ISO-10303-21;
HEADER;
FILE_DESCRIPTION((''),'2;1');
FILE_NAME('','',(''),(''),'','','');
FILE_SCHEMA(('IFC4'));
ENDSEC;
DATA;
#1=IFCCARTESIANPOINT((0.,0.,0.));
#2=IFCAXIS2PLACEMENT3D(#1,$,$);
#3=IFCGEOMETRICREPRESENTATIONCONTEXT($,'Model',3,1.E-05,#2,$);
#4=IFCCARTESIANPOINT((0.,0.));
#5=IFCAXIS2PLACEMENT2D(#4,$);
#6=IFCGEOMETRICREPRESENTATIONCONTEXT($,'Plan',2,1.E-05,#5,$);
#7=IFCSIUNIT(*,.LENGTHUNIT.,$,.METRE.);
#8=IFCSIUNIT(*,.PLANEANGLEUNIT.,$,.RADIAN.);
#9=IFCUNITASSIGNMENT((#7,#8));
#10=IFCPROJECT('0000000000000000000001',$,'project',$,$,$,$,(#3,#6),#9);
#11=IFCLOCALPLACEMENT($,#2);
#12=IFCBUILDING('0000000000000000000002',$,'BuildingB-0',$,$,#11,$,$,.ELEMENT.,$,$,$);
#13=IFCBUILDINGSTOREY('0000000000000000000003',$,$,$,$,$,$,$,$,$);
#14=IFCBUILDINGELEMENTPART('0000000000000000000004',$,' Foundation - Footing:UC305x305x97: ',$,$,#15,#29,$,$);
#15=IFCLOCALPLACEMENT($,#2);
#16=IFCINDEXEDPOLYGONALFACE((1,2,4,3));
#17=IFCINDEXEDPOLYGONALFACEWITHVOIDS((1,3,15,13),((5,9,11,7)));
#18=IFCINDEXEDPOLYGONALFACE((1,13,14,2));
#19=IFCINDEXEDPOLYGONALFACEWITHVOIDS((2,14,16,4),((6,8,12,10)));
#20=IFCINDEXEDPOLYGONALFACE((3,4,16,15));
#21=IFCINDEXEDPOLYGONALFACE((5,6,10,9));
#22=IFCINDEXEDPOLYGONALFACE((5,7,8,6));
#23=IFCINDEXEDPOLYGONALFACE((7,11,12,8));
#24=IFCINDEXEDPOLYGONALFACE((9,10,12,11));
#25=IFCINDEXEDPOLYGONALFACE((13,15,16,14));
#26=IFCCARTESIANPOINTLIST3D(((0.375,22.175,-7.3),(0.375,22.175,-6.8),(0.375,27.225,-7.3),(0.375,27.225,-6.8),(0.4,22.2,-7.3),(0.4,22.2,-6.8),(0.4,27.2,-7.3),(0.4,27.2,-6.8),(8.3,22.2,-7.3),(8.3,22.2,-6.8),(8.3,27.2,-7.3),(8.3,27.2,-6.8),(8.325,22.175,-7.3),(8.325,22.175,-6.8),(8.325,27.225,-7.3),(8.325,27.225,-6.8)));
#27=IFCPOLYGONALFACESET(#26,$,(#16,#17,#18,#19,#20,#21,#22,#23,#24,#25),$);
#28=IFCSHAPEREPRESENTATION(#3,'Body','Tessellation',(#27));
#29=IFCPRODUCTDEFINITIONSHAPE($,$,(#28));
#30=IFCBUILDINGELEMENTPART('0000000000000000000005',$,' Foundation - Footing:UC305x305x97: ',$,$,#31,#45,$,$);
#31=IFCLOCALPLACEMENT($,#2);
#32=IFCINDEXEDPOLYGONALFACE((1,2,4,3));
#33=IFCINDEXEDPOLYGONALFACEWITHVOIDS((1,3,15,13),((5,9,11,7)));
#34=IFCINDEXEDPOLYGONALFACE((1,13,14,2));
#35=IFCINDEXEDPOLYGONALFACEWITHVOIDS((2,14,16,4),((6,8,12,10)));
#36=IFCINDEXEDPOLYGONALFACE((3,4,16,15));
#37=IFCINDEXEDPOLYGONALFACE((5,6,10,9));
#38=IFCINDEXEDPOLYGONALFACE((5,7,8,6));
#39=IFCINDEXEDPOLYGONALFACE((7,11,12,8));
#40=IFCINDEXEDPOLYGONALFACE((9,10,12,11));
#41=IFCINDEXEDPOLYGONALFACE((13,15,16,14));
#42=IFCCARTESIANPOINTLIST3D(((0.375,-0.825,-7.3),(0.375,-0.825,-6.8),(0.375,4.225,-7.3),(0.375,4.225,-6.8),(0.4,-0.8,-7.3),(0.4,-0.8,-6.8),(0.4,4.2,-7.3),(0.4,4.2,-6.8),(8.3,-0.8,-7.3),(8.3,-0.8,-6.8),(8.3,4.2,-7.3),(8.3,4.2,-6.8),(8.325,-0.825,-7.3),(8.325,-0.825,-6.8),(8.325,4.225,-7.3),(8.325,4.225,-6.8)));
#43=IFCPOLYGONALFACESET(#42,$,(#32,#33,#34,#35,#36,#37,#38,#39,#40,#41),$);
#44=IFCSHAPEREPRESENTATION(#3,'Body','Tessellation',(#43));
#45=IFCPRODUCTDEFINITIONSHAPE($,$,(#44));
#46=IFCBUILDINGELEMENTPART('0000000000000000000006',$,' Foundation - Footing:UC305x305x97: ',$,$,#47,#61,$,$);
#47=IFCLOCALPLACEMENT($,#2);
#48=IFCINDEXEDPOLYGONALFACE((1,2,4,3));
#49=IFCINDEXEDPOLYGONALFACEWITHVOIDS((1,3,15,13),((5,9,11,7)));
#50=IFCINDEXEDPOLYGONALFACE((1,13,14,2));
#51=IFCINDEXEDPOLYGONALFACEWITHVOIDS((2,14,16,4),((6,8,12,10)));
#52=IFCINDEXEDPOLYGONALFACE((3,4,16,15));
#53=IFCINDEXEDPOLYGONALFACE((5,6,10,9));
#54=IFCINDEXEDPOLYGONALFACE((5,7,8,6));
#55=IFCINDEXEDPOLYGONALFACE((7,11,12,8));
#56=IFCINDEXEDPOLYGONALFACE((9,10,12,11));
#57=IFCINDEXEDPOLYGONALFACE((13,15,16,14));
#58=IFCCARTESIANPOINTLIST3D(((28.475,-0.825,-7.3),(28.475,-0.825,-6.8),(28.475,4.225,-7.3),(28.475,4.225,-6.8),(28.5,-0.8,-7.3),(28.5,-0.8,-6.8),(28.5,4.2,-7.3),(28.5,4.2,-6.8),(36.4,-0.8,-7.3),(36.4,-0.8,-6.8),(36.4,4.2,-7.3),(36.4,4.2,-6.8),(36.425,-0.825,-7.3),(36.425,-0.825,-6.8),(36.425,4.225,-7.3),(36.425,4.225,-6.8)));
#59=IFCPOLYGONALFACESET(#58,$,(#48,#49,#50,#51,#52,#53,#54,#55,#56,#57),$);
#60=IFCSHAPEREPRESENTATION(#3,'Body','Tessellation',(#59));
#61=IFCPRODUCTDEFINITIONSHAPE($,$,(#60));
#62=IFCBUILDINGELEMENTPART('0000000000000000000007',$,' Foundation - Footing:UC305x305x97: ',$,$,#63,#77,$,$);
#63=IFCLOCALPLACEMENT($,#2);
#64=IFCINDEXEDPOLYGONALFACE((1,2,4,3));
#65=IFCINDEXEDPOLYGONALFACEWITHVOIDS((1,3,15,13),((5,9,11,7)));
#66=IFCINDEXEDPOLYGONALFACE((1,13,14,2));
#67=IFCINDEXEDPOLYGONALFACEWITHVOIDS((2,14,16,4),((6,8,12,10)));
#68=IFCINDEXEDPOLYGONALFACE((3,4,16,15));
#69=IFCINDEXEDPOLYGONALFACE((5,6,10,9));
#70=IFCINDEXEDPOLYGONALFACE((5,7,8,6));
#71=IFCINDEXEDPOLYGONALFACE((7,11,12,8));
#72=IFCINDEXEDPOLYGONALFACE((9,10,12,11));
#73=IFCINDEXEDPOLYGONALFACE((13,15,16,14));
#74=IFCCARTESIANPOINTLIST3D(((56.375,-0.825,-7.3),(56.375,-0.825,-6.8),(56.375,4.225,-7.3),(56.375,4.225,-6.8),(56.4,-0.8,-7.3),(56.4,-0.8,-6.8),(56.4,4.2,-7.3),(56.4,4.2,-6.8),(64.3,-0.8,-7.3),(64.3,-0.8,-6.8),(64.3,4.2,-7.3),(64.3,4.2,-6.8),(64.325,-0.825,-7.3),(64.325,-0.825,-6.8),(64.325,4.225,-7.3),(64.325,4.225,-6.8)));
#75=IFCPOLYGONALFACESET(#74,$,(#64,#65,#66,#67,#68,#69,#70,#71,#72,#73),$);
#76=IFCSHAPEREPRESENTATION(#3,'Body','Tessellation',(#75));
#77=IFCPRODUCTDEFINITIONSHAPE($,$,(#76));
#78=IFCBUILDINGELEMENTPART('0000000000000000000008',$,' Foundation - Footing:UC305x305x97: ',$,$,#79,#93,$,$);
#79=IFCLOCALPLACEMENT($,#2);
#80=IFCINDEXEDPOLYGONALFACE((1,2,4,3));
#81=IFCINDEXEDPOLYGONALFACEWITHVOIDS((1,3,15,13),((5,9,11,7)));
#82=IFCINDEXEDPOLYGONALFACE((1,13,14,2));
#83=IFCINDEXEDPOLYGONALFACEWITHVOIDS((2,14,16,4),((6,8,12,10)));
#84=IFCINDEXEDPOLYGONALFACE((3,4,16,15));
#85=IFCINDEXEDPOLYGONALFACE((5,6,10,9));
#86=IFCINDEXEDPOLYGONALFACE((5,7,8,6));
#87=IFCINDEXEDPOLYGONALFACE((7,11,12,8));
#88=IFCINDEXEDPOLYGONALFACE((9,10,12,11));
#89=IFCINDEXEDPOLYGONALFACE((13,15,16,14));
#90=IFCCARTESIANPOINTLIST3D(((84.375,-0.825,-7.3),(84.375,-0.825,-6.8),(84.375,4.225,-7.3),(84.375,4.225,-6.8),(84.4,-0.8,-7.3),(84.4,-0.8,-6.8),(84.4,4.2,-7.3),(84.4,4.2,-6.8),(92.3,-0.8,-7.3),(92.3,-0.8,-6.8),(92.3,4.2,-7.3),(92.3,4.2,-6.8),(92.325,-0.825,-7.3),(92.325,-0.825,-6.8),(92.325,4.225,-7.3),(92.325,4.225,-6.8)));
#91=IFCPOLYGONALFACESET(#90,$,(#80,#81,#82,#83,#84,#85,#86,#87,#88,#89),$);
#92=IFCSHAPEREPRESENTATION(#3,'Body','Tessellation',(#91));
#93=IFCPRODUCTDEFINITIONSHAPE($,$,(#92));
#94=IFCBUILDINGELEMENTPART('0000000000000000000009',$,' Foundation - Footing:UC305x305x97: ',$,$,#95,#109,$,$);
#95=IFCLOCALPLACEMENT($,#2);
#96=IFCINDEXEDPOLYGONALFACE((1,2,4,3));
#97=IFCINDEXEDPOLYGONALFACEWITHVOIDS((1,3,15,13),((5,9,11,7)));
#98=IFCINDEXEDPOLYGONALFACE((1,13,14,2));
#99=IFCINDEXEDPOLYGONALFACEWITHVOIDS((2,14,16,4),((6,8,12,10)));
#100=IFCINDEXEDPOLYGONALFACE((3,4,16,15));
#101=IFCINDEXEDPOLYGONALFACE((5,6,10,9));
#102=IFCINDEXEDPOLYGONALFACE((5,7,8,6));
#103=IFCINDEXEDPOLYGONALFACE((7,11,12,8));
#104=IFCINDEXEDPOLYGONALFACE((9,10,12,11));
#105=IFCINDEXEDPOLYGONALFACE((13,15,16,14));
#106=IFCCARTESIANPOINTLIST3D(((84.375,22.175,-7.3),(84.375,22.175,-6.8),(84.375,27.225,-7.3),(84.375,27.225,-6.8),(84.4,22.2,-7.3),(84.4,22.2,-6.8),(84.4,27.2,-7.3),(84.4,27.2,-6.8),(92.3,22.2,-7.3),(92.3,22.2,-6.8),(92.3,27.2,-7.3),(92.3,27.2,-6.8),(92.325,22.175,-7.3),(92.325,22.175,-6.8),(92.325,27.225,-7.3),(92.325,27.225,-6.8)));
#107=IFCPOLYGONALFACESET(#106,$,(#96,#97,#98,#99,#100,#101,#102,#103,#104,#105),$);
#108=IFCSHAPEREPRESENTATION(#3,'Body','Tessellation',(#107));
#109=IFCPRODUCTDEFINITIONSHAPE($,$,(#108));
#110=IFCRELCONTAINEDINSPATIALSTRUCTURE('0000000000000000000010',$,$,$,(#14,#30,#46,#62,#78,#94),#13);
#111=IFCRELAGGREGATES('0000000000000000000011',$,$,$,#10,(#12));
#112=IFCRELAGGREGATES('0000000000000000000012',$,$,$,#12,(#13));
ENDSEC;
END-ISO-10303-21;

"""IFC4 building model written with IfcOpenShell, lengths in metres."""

from ifc_helpers import new_model, si_unit, origin, origin_2d, place, context, project, spatial, polyline, outline, extrude, element, save


model = new_model("IFC4")

# Units and contexts
model_context = context("Model", 3, precision=1e-05, world=origin())
plan_context = context("Plan", 2, precision=1e-05, world=origin_2d())
ifc_project = project(units=[si_unit("LENGTHUNIT", "METRE"), si_unit("PLANEANGLEUNIT", "RADIAN")], contexts=[model_context, plan_context])

# Building, storey
building_placement = place(None, origin())
building = spatial("IfcBuilding", under=ifc_project, at=building_placement, Name="BuildingB-0", CompositionType="ELEMENT")
storey = spatial("IfcBuildingStorey", under=building)

# Building element parts, openings
building_element_part_1 = element("IfcBuildingElementPart", 1, inside=storey, Name=" Foundation - Footing:UC305x305x97: ", context=model_context, shape_type="SweptSolid", body=[
    extrude(outline(polyline([(8.325, 27.225, -7.3), (0.375, 27.225, -7.3), (0.375, 22.175, -7.3), (8.325, 22.175, -7.3), (8.325, 27.225, -7.3)])), None, (0.0, 0.0, 1.0), 0.5),
])
element("IfcOpeningElement", 2, inside=storey, cuts=building_element_part_1, context=model_context, shape_type="SweptSolid", body=[
    extrude(outline(polyline([(8.3, 27.2, -7.3), (0.4, 27.2, -7.3), (0.4, 22.2, -7.3), (8.3, 22.2, -7.3), (8.3, 27.2, -7.3)])), None, (0.0, 0.0, 1.0), 0.5),
])
building_element_part_2 = element("IfcBuildingElementPart", 3, inside=storey, Name=" Foundation - Footing:UC305x305x97: ", context=model_context, shape_type="SweptSolid", body=[
    extrude(outline(polyline([(8.325, 4.225, -7.3), (0.375, 4.225, -7.3), (0.375, -0.825, -7.3), (8.325, -0.825, -7.3), (8.325, 4.225, -7.3)])), None, (0.0, 0.0, 1.0), 0.5),
])
element("IfcOpeningElement", 4, inside=storey, cuts=building_element_part_2, context=model_context, shape_type="SweptSolid", body=[
    extrude(outline(polyline([(8.3, 4.2, -7.3), (0.4, 4.2, -7.3), (0.4, -0.8, -7.3), (8.3, -0.8, -7.3), (8.3, 4.2, -7.3)])), None, (0.0, 0.0, 1.0), 0.5),
])
building_element_part_3 = element("IfcBuildingElementPart", 5, inside=storey, Name=" Foundation - Footing:UC305x305x97: ", context=model_context, shape_type="SweptSolid", body=[
    extrude(outline(polyline([(36.425, 4.225, -7.3), (28.475, 4.225, -7.3), (28.475, -0.825, -7.3), (36.425, -0.825, -7.3), (36.425, 4.225, -7.3)])), None, (0.0, 0.0, 1.0), 0.5),
])
element("IfcOpeningElement", 6, inside=storey, cuts=building_element_part_3, context=model_context, shape_type="SweptSolid", body=[
    extrude(outline(polyline([(36.4, 4.2, -7.3), (28.5, 4.2, -7.3), (28.5, -0.8, -7.3), (36.4, -0.8, -7.3), (36.4, 4.2, -7.3)])), None, (0.0, 0.0, 1.0), 0.5),
])
building_element_part_4 = element("IfcBuildingElementPart", 7, inside=storey, Name=" Foundation - Footing:UC305x305x97: ", context=model_context, shape_type="SweptSolid", body=[
    extrude(outline(polyline([(64.325, 4.225, -7.3), (56.375, 4.225, -7.3), (56.375, -0.825, -7.3), (64.325, -0.825, -7.3), (64.325, 4.225, -7.3)])), None, (0.0, 0.0, 1.0), 0.5),
])
element("IfcOpeningElement", 8, inside=storey, cuts=building_element_part_4, context=model_context, shape_type="SweptSolid", body=[
    extrude(outline(polyline([(64.3, 4.2, -7.3), (56.4, 4.2, -7.3), (56.4, -0.8, -7.3), (64.3, -0.8, -7.3), (64.3, 4.2, -7.3)])), None, (0.0, 0.0, 1.0), 0.5),
])
building_element_part_5 = element("IfcBuildingElementPart", 9, inside=storey, Name=" Foundation - Footing:UC305x305x97: ", context=model_context, shape_type="SweptSolid", body=[
    extrude(outline(polyline([(92.325, 4.225, -7.3), (84.375, 4.225, -7.3), (84.375, -0.825, -7.3), (92.325, -0.825, -7.3), (92.325, 4.225, -7.3)])), None, (0.0, 0.0, 1.0), 0.5),
])
element("IfcOpeningElement", 10, inside=storey, cuts=building_element_part_5, context=model_context, shape_type="SweptSolid", body=[
    extrude(outline(polyline([(92.3, 4.2, -7.3), (84.4, 4.2, -7.3), (84.4, -0.8, -7.3), (92.3, -0.8, -7.3), (92.3, 4.2, -7.3)])), None, (0.0, 0.0, 1.0), 0.5),
])
building_element_part_6 = element("IfcBuildingElementPart", 11, inside=storey, Name=" Foundation - Footing:UC305x305x97: ", context=model_context, shape_type="SweptSolid", body=[
    extrude(outline(polyline([(92.325, 27.225, -7.3), (84.375, 27.225, -7.3), (84.375, 22.175, -7.3), (92.325, 22.175, -7.3), (92.325, 27.225, -7.3)])), None, (0.0, 0.0, 1.0), 0.5),
])
element("IfcOpeningElement", 12, inside=storey, cuts=building_element_part_6, context=model_context, shape_type="SweptSolid", body=[
    extrude(outline(polyline([(92.3, 27.2, -7.3), (84.4, 27.2, -7.3), (84.4, 22.2, -7.3), (92.3, 22.2, -7.3), (92.3, 27.2, -7.3)])), None, (0.0, 0.0, 1.0), 0.5),
])

save(model, "model.ifc")
